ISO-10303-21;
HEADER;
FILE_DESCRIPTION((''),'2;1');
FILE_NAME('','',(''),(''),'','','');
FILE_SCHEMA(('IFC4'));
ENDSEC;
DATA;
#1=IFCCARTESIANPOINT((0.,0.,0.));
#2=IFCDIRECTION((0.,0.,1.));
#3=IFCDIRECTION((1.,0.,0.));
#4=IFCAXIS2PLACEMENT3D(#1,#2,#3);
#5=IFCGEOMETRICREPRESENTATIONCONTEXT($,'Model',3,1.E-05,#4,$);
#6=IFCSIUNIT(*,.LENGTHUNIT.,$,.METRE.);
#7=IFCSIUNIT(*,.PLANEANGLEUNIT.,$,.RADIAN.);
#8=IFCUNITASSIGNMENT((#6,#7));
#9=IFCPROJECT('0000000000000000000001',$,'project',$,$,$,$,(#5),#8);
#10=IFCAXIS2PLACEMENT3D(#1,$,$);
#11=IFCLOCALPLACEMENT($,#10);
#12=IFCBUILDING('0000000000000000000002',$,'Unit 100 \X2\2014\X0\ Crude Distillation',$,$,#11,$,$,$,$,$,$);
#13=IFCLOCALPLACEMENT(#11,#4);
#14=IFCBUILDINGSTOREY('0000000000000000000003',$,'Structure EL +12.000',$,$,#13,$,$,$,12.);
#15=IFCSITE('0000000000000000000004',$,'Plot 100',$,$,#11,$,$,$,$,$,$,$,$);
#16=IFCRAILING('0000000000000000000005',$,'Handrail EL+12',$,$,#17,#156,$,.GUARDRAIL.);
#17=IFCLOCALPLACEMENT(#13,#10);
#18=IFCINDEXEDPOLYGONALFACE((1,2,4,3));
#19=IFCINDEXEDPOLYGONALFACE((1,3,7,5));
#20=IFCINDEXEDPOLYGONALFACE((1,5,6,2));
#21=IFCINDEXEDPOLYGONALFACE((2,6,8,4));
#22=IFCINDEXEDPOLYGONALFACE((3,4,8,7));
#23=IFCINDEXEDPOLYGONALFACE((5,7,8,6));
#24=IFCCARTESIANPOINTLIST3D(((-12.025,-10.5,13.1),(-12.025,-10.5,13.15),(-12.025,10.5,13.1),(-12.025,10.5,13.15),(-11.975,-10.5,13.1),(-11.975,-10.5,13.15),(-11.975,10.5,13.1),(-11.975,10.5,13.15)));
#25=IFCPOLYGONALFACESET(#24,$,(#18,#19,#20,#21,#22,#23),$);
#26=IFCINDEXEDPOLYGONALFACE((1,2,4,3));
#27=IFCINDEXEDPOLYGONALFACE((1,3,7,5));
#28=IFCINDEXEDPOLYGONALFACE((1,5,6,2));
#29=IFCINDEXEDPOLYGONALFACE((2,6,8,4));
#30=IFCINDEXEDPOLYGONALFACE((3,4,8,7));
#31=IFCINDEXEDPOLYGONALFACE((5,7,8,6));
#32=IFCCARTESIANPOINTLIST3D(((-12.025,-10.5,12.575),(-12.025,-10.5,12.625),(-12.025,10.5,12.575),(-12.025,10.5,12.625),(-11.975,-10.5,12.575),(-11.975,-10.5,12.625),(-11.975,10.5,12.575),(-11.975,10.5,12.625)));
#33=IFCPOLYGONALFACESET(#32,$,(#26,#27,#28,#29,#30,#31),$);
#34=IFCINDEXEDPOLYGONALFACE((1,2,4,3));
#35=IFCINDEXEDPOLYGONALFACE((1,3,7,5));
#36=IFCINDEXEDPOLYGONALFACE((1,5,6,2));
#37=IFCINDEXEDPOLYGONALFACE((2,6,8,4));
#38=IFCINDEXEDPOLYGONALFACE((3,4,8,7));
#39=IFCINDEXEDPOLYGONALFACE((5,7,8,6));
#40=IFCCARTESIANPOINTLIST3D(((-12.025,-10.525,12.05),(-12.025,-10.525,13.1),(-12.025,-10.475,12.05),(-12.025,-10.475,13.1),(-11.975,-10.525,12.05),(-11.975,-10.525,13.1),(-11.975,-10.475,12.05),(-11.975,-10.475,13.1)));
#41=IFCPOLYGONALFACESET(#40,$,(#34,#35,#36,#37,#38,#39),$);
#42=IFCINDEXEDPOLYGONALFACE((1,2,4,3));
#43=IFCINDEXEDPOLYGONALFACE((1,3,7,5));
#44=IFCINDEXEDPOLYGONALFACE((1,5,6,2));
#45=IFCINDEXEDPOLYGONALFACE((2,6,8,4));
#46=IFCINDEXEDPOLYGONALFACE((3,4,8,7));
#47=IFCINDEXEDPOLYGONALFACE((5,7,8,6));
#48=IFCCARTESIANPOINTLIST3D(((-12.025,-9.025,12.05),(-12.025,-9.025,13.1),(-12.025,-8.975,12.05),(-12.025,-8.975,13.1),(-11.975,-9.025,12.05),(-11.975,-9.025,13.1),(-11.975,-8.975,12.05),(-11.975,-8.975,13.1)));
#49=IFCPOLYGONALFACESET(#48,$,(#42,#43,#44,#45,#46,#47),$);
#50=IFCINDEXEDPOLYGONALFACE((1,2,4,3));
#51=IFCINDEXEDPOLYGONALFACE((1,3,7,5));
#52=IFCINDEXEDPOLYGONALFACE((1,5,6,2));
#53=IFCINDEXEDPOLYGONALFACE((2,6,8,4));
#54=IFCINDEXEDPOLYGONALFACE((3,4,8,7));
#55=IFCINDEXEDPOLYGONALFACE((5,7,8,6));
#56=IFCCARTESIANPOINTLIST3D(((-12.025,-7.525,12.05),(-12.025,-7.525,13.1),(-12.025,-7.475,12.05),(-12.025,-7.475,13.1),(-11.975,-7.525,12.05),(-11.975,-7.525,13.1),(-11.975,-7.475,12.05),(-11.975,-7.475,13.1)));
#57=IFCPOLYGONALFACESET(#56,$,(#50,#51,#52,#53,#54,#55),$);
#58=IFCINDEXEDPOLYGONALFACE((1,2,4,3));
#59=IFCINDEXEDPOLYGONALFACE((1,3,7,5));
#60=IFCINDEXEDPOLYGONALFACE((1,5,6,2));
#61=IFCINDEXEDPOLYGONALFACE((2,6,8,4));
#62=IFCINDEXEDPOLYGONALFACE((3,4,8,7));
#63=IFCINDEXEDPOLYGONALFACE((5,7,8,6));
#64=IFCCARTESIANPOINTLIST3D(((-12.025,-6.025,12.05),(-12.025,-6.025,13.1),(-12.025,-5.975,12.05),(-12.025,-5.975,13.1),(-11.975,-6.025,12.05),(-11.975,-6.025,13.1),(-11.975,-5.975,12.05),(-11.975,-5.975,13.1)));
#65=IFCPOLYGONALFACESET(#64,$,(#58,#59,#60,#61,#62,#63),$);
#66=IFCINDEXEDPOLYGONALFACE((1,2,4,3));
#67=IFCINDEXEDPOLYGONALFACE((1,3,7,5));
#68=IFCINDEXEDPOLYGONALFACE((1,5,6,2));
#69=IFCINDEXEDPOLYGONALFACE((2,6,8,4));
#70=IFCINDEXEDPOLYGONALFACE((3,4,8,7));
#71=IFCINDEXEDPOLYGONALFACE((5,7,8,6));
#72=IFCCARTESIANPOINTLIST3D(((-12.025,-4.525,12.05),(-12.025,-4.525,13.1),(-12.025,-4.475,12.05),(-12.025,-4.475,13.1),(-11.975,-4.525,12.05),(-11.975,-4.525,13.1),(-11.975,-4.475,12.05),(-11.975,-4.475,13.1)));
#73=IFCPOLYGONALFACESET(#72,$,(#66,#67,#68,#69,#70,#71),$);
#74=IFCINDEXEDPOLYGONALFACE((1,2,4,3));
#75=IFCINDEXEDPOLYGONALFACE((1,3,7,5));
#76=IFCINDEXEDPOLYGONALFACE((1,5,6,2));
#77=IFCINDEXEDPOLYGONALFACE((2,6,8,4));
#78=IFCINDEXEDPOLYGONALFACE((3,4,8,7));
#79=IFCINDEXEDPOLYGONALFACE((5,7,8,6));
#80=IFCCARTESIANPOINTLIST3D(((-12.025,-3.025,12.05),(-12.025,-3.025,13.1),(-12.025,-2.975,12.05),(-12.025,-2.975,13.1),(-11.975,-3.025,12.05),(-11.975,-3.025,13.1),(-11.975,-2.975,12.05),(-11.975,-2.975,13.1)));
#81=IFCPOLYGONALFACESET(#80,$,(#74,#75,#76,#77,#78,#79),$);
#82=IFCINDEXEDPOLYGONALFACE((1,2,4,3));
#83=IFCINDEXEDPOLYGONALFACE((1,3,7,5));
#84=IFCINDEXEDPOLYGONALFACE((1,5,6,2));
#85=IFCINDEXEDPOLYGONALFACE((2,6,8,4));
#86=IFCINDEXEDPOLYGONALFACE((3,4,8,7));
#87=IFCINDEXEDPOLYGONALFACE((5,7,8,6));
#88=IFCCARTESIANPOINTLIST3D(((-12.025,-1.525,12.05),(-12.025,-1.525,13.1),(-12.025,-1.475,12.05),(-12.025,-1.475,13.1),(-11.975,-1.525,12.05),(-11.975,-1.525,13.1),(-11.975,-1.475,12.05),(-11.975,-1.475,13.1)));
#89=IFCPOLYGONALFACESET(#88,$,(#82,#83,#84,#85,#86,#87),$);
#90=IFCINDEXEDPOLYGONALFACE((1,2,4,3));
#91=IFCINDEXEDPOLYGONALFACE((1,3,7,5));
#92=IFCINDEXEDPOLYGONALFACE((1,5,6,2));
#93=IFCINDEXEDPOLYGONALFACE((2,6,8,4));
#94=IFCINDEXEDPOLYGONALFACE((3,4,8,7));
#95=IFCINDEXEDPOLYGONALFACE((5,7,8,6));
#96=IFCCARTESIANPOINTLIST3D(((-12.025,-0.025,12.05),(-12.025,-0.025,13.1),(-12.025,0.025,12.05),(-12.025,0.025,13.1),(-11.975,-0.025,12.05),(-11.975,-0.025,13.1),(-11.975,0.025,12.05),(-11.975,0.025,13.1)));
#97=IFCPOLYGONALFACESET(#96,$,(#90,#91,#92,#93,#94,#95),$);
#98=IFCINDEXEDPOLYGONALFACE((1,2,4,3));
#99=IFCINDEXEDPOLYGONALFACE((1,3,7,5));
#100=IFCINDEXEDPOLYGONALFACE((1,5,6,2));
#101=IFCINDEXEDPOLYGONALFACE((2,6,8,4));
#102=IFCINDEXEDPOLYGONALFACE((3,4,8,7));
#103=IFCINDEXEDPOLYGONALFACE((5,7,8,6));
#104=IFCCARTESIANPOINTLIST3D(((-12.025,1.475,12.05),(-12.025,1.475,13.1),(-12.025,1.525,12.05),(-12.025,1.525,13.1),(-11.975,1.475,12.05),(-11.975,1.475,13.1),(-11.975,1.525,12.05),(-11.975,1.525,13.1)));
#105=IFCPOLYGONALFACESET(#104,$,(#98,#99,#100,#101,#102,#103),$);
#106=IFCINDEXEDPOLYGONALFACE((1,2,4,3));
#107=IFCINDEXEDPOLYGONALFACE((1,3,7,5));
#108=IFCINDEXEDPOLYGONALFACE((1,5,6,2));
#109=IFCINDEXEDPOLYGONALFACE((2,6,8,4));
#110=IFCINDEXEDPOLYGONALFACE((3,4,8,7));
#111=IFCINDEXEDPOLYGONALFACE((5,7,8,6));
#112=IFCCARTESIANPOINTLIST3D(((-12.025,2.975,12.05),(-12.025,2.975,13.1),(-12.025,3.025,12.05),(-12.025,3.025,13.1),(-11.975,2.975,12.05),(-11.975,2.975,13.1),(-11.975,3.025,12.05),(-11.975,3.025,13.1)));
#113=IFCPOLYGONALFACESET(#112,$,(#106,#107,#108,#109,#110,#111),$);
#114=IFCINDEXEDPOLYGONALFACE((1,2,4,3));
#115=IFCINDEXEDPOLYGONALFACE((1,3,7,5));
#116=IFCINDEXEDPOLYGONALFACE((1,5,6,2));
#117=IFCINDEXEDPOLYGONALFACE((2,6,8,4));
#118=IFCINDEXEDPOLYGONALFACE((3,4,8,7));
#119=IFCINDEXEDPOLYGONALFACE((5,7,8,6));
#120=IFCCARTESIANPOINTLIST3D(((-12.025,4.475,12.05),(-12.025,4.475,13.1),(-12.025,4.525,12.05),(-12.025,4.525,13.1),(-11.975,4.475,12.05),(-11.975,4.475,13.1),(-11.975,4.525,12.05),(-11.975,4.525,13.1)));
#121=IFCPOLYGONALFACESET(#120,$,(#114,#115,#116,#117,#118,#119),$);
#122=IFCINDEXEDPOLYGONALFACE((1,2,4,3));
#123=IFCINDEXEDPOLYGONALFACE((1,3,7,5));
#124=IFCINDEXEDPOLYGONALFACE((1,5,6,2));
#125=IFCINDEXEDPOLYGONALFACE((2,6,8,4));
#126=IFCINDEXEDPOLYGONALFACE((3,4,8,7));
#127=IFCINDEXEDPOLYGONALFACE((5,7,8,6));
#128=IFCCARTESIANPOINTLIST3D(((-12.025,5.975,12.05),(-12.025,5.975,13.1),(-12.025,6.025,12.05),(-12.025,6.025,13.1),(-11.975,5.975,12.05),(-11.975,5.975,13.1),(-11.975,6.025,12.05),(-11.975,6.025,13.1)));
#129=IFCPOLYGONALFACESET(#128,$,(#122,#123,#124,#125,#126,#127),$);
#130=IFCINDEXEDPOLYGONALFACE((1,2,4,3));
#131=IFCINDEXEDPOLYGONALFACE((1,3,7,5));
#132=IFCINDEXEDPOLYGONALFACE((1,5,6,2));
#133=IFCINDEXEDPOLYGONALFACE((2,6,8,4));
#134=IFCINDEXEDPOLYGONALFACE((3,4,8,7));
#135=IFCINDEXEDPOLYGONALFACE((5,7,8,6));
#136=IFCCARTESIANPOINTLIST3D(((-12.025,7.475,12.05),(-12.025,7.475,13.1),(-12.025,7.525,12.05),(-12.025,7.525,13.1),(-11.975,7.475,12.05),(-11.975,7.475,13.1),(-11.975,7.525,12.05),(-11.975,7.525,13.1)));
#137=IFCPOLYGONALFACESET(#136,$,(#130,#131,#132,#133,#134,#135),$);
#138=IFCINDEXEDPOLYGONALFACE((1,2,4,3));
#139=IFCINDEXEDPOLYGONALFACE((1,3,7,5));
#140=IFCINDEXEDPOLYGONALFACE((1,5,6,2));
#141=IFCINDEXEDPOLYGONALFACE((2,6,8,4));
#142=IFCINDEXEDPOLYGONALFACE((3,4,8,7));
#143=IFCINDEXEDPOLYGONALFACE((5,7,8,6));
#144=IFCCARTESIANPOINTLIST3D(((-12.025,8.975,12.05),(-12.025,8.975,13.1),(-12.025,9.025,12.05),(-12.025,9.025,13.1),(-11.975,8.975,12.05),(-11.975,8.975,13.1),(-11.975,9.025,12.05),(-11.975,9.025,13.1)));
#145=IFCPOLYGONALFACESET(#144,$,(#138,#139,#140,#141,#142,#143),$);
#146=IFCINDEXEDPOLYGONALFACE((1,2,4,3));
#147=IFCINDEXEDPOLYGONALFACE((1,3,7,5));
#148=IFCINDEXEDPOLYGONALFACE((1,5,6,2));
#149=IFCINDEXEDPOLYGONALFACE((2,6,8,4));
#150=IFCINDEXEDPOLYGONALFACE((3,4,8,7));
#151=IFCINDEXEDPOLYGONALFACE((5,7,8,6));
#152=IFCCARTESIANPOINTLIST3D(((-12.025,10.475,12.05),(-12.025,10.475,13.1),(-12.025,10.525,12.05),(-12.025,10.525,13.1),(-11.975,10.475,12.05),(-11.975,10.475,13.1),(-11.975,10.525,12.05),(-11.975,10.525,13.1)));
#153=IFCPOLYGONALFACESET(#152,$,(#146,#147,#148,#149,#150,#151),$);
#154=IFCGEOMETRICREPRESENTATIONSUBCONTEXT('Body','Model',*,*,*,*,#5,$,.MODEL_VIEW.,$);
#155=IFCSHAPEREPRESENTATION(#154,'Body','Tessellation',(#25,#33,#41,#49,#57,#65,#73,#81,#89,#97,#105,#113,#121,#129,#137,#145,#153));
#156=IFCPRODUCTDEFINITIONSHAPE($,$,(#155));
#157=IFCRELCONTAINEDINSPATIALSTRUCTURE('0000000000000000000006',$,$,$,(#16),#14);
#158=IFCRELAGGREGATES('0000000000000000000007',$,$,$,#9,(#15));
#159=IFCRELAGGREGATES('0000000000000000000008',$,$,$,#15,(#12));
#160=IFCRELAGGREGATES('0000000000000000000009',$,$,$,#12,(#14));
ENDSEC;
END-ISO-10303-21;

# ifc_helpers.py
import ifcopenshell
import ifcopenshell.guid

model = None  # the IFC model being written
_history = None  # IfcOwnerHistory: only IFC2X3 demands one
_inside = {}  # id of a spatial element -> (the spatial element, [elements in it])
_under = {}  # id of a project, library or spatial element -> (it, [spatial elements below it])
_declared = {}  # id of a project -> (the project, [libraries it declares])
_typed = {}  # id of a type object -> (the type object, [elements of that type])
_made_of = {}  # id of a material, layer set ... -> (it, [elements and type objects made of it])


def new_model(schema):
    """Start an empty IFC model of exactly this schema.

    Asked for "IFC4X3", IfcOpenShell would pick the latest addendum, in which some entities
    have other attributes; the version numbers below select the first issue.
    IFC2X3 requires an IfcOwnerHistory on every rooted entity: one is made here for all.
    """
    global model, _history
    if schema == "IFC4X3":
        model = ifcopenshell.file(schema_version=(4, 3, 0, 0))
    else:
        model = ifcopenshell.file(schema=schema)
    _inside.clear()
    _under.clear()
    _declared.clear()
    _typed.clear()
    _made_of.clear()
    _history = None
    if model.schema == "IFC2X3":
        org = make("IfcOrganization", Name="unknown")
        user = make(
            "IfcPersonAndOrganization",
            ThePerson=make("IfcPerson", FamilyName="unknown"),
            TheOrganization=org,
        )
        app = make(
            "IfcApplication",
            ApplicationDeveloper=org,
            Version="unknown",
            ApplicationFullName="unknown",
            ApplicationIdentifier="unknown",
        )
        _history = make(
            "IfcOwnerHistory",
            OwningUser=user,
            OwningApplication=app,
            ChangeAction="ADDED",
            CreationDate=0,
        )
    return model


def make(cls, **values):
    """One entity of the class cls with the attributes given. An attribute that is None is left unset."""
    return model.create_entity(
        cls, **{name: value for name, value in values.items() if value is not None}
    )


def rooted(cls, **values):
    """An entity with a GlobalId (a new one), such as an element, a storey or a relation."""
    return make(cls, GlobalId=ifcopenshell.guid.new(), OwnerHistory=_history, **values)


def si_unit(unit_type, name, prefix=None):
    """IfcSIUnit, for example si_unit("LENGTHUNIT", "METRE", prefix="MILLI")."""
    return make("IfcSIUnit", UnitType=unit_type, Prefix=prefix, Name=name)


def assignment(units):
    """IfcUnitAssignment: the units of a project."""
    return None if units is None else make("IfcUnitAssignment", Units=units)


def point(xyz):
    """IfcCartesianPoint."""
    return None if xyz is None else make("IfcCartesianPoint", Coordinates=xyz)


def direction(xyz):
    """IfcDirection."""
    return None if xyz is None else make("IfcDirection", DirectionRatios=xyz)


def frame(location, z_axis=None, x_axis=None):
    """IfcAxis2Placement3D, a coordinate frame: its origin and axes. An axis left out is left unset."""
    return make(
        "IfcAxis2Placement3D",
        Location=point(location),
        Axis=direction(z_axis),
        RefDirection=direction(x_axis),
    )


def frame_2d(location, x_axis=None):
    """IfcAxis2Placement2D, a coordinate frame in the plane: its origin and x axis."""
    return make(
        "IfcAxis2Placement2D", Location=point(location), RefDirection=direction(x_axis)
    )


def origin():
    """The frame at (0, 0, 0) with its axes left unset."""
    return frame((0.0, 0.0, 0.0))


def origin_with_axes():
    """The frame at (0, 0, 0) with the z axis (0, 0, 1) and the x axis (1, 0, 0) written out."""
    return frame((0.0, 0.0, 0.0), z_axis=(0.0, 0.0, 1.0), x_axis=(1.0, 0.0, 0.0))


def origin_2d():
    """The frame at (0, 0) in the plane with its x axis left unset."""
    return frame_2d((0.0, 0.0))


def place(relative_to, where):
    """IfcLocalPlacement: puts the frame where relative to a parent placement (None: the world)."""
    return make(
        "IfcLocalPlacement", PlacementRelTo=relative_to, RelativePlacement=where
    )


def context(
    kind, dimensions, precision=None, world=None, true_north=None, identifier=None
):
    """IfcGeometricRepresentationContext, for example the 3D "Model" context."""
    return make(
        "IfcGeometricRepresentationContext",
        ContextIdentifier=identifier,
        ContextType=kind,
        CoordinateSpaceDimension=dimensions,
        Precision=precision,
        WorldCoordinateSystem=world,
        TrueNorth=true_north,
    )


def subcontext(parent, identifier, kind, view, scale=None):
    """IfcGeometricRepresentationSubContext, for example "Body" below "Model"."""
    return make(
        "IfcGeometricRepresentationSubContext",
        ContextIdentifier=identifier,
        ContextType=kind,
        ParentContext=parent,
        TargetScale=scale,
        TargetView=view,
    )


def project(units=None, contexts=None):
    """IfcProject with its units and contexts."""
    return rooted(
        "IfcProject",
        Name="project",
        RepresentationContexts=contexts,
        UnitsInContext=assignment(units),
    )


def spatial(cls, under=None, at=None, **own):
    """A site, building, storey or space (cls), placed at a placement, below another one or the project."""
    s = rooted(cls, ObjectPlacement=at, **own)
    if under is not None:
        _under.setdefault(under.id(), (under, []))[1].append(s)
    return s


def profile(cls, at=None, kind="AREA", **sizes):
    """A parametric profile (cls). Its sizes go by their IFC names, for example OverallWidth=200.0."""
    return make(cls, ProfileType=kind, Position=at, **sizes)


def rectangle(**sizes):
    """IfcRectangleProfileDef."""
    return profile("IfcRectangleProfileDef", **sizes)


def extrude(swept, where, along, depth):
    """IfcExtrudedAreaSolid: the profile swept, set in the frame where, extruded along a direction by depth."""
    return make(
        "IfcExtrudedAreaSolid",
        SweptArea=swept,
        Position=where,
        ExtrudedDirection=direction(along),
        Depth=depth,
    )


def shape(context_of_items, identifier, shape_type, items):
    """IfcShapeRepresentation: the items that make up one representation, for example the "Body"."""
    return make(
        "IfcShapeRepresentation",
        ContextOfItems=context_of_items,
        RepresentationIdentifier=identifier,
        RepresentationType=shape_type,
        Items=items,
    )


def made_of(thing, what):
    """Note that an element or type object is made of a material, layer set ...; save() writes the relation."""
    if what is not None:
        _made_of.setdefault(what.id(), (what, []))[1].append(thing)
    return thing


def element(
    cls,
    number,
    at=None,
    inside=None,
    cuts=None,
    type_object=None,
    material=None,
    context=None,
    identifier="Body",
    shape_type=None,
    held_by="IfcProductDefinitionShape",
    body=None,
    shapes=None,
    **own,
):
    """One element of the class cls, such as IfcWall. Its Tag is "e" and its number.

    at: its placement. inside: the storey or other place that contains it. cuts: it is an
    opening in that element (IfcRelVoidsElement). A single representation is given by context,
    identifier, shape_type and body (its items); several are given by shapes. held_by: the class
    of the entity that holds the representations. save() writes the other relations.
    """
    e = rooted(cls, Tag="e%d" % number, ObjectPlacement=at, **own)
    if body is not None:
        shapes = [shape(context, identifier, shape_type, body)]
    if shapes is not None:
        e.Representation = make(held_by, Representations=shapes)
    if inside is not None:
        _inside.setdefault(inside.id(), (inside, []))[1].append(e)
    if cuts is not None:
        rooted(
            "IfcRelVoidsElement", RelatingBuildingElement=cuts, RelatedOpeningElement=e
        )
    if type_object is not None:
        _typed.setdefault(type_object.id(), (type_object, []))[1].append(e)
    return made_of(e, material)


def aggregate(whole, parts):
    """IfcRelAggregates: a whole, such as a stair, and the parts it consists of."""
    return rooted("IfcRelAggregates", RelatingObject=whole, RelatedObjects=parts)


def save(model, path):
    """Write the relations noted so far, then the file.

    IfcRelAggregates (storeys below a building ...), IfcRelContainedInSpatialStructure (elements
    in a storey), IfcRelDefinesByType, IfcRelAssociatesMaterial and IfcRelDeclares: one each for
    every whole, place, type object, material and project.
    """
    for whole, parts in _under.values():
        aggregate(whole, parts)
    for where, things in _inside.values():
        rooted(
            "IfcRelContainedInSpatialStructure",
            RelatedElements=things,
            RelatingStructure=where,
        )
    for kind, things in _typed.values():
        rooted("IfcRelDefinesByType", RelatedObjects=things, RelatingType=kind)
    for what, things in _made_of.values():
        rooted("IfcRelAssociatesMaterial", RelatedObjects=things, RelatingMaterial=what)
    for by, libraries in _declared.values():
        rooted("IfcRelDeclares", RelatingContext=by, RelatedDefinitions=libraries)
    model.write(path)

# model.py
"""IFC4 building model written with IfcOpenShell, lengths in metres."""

from ifc_helpers import new_model, si_unit, frame, origin, origin_with_axes, origin_2d, place, context, subcontext, project, spatial, rectangle, extrude, element, save


model = new_model("IFC4")

# Units and contexts
model_context = context("Model", 3, precision=1e-05, world=origin_with_axes())
body_context = subcontext(model_context, "Body", "Model", "MODEL_VIEW")
ifc_project = project(units=[si_unit("LENGTHUNIT", "METRE"), si_unit("PLANEANGLEUNIT", "RADIAN")], contexts=[model_context])

# Site, building, storey
placement = place(None, origin())
site = spatial("IfcSite", under=ifc_project, at=placement, Name="Plot 100")
building = spatial("IfcBuilding", under=site, at=placement, Name="Unit 100 — Crude Distillation")
storey_placement = place(placement, origin_with_axes())
storey = spatial("IfcBuildingStorey", under=building, at=storey_placement, Name="Structure EL +12.000", Elevation=12.0)

# Railing
railing_1_placement = place(storey_placement, origin_with_axes())
element("IfcRailing", 1, at=railing_1_placement, inside=storey, Name="Handrail EL+12", PredefinedType="GUARDRAIL", context=body_context, shape_type="SweptSolid", body=[
    extrude(rectangle(XDim=0.05, YDim=0.05, at=origin_2d()), frame((-12.0, -10.5, 13.125), z_axis=(0.0, 1.0, 0.0), x_axis=(-1.0, 0.0, 0.0)), (0.0, 0.0, 1.0), 21.0),
    extrude(rectangle(XDim=0.05, YDim=0.05, at=origin_2d()), frame((-12.0, -10.5, 12.6), z_axis=(0.0, 1.0, 0.0), x_axis=(-1.0, 0.0, 0.0)), (0.0, 0.0, 1.0), 21.0),
    extrude(rectangle(XDim=0.05, YDim=0.05, at=origin_2d()), frame((-12.0, -10.5, 12.05), z_axis=(0.0, 0.0, 1.0), x_axis=(1.0, 0.0, 0.0)), (0.0, 0.0, 1.0), 1.05),
    extrude(rectangle(XDim=0.05, YDim=0.05, at=origin_2d()), frame((-12.0, -9.0, 12.05), z_axis=(0.0, 0.0, 1.0), x_axis=(1.0, 0.0, 0.0)), (0.0, 0.0, 1.0), 1.05),
    extrude(rectangle(XDim=0.05, YDim=0.05, at=origin_2d()), frame((-12.0, -7.5, 12.05), z_axis=(0.0, 0.0, 1.0), x_axis=(1.0, 0.0, 0.0)), (0.0, 0.0, 1.0), 1.05),
    extrude(rectangle(XDim=0.05, YDim=0.05, at=origin_2d()), frame((-12.0, -6.0, 12.05), z_axis=(0.0, 0.0, 1.0), x_axis=(1.0, 0.0, 0.0)), (0.0, 0.0, 1.0), 1.05),
    extrude(rectangle(XDim=0.05, YDim=0.05, at=origin_2d()), frame((-12.0, -4.5, 12.05), z_axis=(0.0, 0.0, 1.0), x_axis=(1.0, 0.0, 0.0)), (0.0, 0.0, 1.0), 1.05),
    extrude(rectangle(XDim=0.05, YDim=0.05, at=origin_2d()), frame((-12.0, -3.0, 12.05), z_axis=(0.0, 0.0, 1.0), x_axis=(1.0, 0.0, 0.0)), (0.0, 0.0, 1.0), 1.05),
    extrude(rectangle(XDim=0.05, YDim=0.05, at=origin_2d()), frame((-12.0, -1.5, 12.05), z_axis=(0.0, 0.0, 1.0), x_axis=(1.0, 0.0, 0.0)), (0.0, 0.0, 1.0), 1.05),
    extrude(rectangle(XDim=0.05, YDim=0.05, at=origin_2d()), frame((-12.0, 0.0, 12.05), z_axis=(0.0, 0.0, 1.0), x_axis=(1.0, 0.0, 0.0)), (0.0, 0.0, 1.0), 1.05),
    extrude(rectangle(XDim=0.05, YDim=0.05, at=origin_2d()), frame((-12.0, 1.5, 12.05), z_axis=(0.0, 0.0, 1.0), x_axis=(1.0, 0.0, 0.0)), (0.0, 0.0, 1.0), 1.05),
    extrude(rectangle(XDim=0.05, YDim=0.05, at=origin_2d()), frame((-12.0, 3.0, 12.05), z_axis=(0.0, 0.0, 1.0), x_axis=(1.0, 0.0, 0.0)), (0.0, 0.0, 1.0), 1.05),
    extrude(rectangle(XDim=0.05, YDim=0.05, at=origin_2d()), frame((-12.0, 4.5, 12.05), z_axis=(0.0, 0.0, 1.0), x_axis=(1.0, 0.0, 0.0)), (0.0, 0.0, 1.0), 1.05),
    extrude(rectangle(XDim=0.05, YDim=0.05, at=origin_2d()), frame((-12.0, 6.0, 12.05), z_axis=(0.0, 0.0, 1.0), x_axis=(1.0, 0.0, 0.0)), (0.0, 0.0, 1.0), 1.05),
    extrude(rectangle(XDim=0.05, YDim=0.05, at=origin_2d()), frame((-12.0, 7.5, 12.05), z_axis=(0.0, 0.0, 1.0), x_axis=(1.0, 0.0, 0.0)), (0.0, 0.0, 1.0), 1.05),
    extrude(rectangle(XDim=0.05, YDim=0.05, at=origin_2d()), frame((-12.0, 9.0, 12.05), z_axis=(0.0, 0.0, 1.0), x_axis=(1.0, 0.0, 0.0)), (0.0, 0.0, 1.0), 1.05),
    extrude(rectangle(XDim=0.05, YDim=0.05, at=origin_2d()), frame((-12.0, 10.5, 12.05), z_axis=(0.0, 0.0, 1.0), x_axis=(1.0, 0.0, 0.0)), (0.0, 0.0, 1.0), 1.05),
])

save(model, "model.ifc")
